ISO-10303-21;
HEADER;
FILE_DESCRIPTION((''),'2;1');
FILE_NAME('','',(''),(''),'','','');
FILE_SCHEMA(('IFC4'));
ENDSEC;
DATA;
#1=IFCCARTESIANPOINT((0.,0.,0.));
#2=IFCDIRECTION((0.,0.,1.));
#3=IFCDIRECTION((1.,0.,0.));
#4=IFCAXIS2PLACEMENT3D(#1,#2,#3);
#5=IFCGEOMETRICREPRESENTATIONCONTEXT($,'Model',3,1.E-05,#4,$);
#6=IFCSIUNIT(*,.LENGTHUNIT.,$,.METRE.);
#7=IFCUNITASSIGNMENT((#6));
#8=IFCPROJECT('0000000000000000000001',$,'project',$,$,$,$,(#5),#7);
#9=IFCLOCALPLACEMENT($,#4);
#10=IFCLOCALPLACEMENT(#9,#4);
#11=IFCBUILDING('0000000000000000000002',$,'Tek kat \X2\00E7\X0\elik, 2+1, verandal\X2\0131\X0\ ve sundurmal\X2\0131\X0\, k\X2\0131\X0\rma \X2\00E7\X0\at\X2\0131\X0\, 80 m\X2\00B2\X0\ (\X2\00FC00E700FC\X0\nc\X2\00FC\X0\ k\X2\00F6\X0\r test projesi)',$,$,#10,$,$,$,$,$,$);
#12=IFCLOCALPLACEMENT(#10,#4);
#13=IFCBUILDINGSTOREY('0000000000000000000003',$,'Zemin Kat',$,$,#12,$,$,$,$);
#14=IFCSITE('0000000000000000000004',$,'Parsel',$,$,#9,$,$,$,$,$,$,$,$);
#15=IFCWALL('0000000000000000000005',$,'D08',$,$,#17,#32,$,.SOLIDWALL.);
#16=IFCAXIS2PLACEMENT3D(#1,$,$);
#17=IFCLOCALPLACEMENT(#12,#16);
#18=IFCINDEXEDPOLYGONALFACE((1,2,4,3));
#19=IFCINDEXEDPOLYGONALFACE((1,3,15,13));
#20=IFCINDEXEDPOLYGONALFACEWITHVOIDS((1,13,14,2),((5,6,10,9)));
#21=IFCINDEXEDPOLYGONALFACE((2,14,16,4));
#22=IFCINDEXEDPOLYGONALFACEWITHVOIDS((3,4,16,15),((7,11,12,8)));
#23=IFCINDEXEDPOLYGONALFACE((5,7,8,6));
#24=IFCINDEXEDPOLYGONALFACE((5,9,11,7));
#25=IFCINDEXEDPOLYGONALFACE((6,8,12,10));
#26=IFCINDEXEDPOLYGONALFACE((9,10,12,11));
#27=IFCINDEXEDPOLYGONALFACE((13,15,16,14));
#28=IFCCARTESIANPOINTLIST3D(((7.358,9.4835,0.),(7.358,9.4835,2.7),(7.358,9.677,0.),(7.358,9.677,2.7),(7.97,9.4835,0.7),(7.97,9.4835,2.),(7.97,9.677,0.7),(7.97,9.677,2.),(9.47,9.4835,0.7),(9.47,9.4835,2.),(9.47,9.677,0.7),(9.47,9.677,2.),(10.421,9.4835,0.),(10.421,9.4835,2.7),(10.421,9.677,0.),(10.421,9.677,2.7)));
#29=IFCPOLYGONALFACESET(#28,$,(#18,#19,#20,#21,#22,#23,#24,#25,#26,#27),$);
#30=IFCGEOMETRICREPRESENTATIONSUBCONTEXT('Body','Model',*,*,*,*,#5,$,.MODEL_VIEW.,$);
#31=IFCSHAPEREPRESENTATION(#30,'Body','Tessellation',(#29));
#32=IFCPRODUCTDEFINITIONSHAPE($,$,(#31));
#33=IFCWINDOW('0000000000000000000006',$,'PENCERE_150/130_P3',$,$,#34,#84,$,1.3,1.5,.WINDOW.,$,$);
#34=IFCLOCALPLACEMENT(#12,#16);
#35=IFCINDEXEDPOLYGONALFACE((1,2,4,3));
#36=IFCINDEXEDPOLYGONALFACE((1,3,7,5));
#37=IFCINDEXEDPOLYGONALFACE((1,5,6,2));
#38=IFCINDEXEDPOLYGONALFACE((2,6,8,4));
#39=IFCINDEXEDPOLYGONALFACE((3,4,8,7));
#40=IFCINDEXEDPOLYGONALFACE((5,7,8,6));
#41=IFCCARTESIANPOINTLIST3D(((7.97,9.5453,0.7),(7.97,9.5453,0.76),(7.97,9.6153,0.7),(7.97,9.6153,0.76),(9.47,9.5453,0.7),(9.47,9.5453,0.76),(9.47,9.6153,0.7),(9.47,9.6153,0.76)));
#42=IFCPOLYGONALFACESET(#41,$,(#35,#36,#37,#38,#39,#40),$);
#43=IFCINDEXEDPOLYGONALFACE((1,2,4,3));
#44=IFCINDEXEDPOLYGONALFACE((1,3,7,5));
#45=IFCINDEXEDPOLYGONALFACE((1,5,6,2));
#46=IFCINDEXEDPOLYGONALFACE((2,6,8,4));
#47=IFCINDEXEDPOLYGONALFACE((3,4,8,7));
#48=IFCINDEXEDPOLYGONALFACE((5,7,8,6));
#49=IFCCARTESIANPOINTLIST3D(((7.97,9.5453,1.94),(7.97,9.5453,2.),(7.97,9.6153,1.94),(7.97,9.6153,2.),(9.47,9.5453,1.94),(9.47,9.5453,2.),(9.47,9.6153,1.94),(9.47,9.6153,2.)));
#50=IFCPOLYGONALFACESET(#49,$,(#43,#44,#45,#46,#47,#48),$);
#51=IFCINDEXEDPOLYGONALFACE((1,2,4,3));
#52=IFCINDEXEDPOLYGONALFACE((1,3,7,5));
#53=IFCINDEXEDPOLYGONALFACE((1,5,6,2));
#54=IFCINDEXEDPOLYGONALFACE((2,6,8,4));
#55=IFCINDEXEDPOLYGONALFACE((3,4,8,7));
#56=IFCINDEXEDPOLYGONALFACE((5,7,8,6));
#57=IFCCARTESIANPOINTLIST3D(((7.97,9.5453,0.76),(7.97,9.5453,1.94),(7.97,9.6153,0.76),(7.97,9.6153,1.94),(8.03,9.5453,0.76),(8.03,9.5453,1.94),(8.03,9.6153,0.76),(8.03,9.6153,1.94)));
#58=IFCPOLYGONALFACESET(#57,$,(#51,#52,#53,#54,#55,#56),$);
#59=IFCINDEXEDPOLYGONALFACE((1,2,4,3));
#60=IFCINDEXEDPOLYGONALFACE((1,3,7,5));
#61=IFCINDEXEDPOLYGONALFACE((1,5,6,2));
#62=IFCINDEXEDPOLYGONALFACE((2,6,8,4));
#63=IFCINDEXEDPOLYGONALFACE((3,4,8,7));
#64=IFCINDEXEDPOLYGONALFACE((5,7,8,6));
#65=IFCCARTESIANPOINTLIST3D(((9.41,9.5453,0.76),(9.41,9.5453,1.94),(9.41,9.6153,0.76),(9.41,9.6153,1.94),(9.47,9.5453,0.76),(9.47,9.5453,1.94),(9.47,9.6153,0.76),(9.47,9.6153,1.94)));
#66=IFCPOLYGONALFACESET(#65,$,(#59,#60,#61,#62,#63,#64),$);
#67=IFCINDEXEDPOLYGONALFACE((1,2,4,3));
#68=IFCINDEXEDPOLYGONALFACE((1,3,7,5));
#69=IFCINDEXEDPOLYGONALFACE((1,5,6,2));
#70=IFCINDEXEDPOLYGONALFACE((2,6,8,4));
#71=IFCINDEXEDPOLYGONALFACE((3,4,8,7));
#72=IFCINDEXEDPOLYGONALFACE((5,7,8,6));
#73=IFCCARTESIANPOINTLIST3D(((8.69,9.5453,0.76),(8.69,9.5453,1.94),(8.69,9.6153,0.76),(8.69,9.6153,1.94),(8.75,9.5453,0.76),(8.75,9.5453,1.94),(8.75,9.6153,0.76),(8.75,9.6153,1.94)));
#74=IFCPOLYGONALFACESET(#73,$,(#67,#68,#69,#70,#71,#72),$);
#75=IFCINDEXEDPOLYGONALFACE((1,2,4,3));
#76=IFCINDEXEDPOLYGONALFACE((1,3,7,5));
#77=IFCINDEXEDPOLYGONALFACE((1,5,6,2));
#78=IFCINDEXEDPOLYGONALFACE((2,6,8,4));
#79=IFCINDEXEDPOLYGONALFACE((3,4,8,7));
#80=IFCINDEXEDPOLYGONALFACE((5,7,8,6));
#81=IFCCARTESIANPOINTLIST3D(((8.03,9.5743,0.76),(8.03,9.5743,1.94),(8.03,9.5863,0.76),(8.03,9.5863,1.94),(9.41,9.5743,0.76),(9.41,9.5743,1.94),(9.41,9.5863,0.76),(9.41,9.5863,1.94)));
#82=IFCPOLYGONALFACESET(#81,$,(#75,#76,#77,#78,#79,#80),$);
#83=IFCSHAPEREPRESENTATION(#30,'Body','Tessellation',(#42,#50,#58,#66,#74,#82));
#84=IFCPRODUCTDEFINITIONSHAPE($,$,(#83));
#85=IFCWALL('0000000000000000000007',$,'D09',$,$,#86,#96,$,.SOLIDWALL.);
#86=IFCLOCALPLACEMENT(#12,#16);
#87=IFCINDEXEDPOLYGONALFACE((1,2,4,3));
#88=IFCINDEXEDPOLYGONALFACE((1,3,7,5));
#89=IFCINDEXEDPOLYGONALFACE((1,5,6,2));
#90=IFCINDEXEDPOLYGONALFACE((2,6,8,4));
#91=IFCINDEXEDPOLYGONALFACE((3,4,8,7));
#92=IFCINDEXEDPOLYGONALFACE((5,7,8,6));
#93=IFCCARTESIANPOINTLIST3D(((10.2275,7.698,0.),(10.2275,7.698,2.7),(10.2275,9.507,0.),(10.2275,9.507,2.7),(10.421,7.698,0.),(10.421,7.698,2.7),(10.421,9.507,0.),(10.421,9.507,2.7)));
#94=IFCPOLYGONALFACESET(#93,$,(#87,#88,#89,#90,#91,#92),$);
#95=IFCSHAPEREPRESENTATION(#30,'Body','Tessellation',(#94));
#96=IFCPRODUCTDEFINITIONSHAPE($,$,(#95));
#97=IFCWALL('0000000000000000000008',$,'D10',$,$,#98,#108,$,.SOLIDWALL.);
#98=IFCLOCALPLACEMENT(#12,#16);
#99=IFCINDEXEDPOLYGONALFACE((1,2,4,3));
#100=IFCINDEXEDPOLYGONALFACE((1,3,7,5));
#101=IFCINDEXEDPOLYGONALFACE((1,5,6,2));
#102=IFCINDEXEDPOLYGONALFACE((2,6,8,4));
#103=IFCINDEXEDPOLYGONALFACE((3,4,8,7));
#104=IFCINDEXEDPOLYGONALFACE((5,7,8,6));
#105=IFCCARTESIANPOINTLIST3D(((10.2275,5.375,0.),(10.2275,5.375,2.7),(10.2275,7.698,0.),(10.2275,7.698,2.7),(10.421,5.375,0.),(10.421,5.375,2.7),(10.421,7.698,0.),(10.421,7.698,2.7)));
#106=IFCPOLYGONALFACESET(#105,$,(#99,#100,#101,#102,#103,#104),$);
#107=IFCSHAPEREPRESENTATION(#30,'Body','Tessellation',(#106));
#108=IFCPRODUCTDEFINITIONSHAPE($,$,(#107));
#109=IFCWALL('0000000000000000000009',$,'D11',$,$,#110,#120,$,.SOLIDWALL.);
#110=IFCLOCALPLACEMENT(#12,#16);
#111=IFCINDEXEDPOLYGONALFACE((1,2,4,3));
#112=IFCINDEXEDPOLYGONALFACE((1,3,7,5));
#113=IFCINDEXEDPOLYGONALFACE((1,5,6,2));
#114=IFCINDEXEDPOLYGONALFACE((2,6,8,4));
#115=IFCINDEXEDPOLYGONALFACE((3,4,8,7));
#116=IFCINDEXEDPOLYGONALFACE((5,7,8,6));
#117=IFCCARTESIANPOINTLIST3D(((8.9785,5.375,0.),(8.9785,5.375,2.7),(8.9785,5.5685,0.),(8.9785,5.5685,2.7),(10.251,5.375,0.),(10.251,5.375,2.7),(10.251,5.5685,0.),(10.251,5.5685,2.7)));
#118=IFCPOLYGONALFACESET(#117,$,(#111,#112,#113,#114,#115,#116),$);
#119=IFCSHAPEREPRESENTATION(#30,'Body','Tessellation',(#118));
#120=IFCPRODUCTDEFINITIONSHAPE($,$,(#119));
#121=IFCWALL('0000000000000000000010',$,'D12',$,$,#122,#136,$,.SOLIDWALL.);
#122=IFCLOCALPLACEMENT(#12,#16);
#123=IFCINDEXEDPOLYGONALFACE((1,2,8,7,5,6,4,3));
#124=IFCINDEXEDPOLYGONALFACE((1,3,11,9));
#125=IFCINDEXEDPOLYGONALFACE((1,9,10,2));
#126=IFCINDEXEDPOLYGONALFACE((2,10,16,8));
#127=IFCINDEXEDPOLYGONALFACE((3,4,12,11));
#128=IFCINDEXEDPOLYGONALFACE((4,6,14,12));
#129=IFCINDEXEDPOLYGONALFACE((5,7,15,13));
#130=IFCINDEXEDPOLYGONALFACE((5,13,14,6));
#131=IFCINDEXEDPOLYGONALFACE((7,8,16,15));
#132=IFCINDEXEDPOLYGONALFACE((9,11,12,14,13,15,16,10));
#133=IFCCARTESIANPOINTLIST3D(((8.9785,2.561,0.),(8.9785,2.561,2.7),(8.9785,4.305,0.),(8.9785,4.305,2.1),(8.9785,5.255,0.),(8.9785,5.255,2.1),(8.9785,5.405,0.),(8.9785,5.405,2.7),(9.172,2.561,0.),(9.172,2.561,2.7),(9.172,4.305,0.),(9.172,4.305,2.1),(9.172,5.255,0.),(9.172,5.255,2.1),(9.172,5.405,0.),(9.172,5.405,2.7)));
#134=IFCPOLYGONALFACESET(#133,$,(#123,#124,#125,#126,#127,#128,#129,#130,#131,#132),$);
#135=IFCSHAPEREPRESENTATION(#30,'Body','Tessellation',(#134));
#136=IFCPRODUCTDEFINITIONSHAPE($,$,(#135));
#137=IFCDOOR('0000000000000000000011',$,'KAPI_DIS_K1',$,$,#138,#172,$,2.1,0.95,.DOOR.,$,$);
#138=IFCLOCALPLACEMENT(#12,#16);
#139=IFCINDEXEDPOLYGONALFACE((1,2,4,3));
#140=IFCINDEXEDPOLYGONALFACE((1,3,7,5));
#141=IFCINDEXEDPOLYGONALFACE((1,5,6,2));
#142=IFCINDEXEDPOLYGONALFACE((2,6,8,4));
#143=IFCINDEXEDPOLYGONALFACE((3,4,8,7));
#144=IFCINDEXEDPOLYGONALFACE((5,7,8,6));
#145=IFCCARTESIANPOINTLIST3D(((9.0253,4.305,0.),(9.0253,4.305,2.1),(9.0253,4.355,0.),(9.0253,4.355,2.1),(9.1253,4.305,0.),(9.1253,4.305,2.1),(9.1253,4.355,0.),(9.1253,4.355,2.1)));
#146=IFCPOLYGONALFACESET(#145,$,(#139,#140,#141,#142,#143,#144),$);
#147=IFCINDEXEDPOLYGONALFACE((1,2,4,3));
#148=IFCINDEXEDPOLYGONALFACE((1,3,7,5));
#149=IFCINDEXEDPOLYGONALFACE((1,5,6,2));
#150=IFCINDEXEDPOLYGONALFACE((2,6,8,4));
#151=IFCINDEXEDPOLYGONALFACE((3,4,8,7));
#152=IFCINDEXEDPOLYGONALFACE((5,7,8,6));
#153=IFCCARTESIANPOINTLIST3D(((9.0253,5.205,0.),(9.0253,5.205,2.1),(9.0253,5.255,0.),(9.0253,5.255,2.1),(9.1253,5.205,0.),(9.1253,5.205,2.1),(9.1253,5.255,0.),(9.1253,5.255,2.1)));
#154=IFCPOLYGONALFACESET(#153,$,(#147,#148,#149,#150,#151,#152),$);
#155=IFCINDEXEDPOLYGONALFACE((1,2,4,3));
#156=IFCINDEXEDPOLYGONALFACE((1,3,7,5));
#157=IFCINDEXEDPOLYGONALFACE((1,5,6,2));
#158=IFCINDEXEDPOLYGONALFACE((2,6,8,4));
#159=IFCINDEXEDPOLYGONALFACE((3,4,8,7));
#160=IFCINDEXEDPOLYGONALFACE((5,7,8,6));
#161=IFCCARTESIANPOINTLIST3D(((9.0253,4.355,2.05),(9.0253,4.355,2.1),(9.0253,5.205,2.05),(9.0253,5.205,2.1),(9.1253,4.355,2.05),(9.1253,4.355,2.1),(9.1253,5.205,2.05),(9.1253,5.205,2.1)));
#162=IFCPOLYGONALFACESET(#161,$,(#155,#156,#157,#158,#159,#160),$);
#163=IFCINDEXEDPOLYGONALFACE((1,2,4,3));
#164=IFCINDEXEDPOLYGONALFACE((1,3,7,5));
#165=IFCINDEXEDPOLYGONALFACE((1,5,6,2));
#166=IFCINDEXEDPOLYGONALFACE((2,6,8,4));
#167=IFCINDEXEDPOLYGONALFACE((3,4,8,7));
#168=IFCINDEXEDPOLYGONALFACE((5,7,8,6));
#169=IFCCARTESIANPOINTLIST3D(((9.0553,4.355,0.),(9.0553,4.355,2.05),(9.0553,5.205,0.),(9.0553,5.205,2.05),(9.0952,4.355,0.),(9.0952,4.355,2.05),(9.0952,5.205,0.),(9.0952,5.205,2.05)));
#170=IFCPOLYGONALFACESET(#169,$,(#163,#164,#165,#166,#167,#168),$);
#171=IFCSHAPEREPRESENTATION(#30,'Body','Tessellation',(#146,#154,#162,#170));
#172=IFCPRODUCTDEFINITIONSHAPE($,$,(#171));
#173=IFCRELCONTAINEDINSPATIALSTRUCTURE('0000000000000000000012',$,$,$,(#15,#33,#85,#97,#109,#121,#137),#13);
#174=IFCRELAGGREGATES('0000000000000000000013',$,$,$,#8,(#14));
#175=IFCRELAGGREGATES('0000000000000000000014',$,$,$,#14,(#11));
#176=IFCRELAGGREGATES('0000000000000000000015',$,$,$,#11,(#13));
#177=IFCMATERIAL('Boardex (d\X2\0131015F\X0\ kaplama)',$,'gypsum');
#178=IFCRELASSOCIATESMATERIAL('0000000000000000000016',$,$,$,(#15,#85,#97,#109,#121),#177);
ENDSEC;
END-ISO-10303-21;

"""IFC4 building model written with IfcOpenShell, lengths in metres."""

from ifc_helpers import new_model, si_unit, frame, origin_with_axes, place, context, subcontext, project, spatial, line, indexed_curve, outline, extrude, material, element, fill, save


model = new_model("IFC4")

# Units and contexts
model_context = context("Model", 3, precision=1e-05, world=origin_with_axes())
body_context = subcontext(model_context, "Body", "Model", "MODEL_VIEW")
ifc_project = project(units=[si_unit("LENGTHUNIT", "METRE")], contexts=[model_context])

# Site, building, storey
site_placement = place(None, origin_with_axes())
site = spatial("IfcSite", under=ifc_project, at=site_placement, Name="Parsel")
building_placement = place(site_placement, origin_with_axes())
building = spatial("IfcBuilding", under=site, at=building_placement, Name="Tek kat çelik, 2+1, verandalı ve sundurmalı, kırma çatı, 80 m² (üçüncü kör test projesi)")
storey_placement = place(building_placement, origin_with_axes())
storey = spatial("IfcBuildingStorey", under=building, at=storey_placement, Name="Zemin Kat")

# Shared definitions
ifc_material_1 = material(Name="Boardex (dış kaplama)", Category="gypsum")

# Wall, opening, window
wall_1_placement = place(storey_placement, origin_with_axes())
wall_1 = element("IfcWall", 1, at=wall_1_placement, inside=storey, material=ifc_material_1, Name="D08", PredefinedType="SOLIDWALL", context=body_context, shape_type="SweptSolid", body=[
    extrude(outline(indexed_curve([(0.0, 0.0), (3.063, 0.0), (3.063, 0.1935), (0.0, 0.1935)], segments=[line(1, 2, 3, 4, 1)])), frame((7.358, 9.4835, 0.0), z_axis=(0.0, 0.0, 1.0), x_axis=(1.0, 0.0, 0.0)), (0.0, 0.0, 1.0), 2.7),
])
opening_1_placement = place(wall_1_placement, origin_with_axes())
opening_1 = element("IfcOpeningElement", 2, at=opening_1_placement, cuts=wall_1, PredefinedType="OPENING", context=body_context, shape_type="SweptSolid", body=[
    extrude(outline(indexed_curve([(0.0, 0.0), (1.5, 0.0), (1.5, 0.2335), (0.0, 0.2335)], segments=[line(1, 2, 3, 4, 1)])), frame((7.97, 9.4635, 0.7), z_axis=(0.0, 0.0, 1.0), x_axis=(1.0, 0.0, 0.0)), (0.0, 0.0, 1.0), 1.3),
])
window_1_placement = place(storey_placement, origin_with_axes())
window_1 = element("IfcWindow", 3, at=window_1_placement, inside=storey, Name="PENCERE_150/130_P3", OverallHeight=1.3, OverallWidth=1.5, PredefinedType="WINDOW", context=body_context, shape_type="SweptSolid", body=[
    extrude(outline(indexed_curve([(0.0, 0.0), (1.5, 0.0), (1.5, 0.07), (0.0, 0.07)], segments=[line(1, 2, 3, 4, 1)])), frame((7.97, 9.5453, 0.7), z_axis=(0.0, 0.0, 1.0), x_axis=(1.0, 0.0, 0.0)), (0.0, 0.0, 1.0), 0.06),
    extrude(outline(indexed_curve([(0.0, 0.0), (1.5, 0.0), (1.5, 0.07), (0.0, 0.07)], segments=[line(1, 2, 3, 4, 1)])), frame((7.97, 9.5453, 1.94), z_axis=(0.0, 0.0, 1.0), x_axis=(1.0, 0.0, 0.0)), (0.0, 0.0, 1.0), 0.06),
    extrude(outline(indexed_curve([(0.0, 0.0), (0.06, 0.0), (0.06, 0.07), (0.0, 0.07)], segments=[line(1, 2, 3, 4, 1)])), frame((7.97, 9.5453, 0.76), z_axis=(0.0, 0.0, 1.0), x_axis=(1.0, 0.0, 0.0)), (0.0, 0.0, 1.0), 1.18),
    extrude(outline(indexed_curve([(0.0, 0.0), (0.06, 0.0), (0.06, 0.07), (0.0, 0.07)], segments=[line(1, 2, 3, 4, 1)])), frame((9.41, 9.5453, 0.76), z_axis=(0.0, 0.0, 1.0), x_axis=(1.0, 0.0, 0.0)), (0.0, 0.0, 1.0), 1.18),
    extrude(outline(indexed_curve([(0.0, 0.0), (0.06, 0.0), (0.06, 0.07), (0.0, 0.07)], segments=[line(1, 2, 3, 4, 1)])), frame((8.69, 9.5453, 0.76), z_axis=(0.0, 0.0, 1.0), x_axis=(1.0, 0.0, 0.0)), (0.0, 0.0, 1.0), 1.18),
    extrude(outline(indexed_curve([(0.0, 0.0), (1.38, 0.0), (1.38, 0.012), (0.0, 0.012)], segments=[line(1, 2, 3, 4, 1)])), frame((8.03, 9.5743, 0.76), z_axis=(0.0, 0.0, 1.0), x_axis=(1.0, 0.0, 0.0)), (0.0, 0.0, 1.0), 1.18),
])
fill(opening_1, window_1)

# Walls
wall_2_placement = place(storey_placement, origin_with_axes())
element("IfcWall", 4, at=wall_2_placement, inside=storey, material=ifc_material_1, Name="D09", PredefinedType="SOLIDWALL", context=body_context, shape_type="SweptSolid", body=[
    extrude(outline(indexed_curve([(0.0, 0.0), (0.1935, 0.0), (0.1935, 1.809), (0.0, 1.809)], segments=[line(1, 2, 3, 4, 1)])), frame((10.2275, 7.698, 0.0), z_axis=(0.0, 0.0, 1.0), x_axis=(1.0, 0.0, 0.0)), (0.0, 0.0, 1.0), 2.7),
])
wall_3_placement = place(storey_placement, origin_with_axes())
element("IfcWall", 5, at=wall_3_placement, inside=storey, material=ifc_material_1, Name="D10", PredefinedType="SOLIDWALL", context=body_context, shape_type="SweptSolid", body=[
    extrude(outline(indexed_curve([(0.0, 0.0), (0.1935, 0.0), (0.1935, 2.323), (0.0, 2.323)], segments=[line(1, 2, 3, 4, 1)])), frame((10.2275, 5.375, 0.0), z_axis=(0.0, 0.0, 1.0), x_axis=(1.0, 0.0, 0.0)), (0.0, 0.0, 1.0), 2.7),
])
wall_4_placement = place(storey_placement, origin_with_axes())
element("IfcWall", 6, at=wall_4_placement, inside=storey, material=ifc_material_1, Name="D11", PredefinedType="SOLIDWALL", context=body_context, shape_type="SweptSolid", body=[
    extrude(outline(indexed_curve([(0.0, 0.0), (1.2725, 0.0), (1.2725, 0.1935), (0.0, 0.1935)], segments=[line(1, 2, 3, 4, 1)])), frame((8.9785, 5.375, 0.0), z_axis=(0.0, 0.0, 1.0), x_axis=(1.0, 0.0, 0.0)), (0.0, 0.0, 1.0), 2.7),
])

# Wall, opening, door
wall_5_placement = place(storey_placement, origin_with_axes())
wall_5 = element("IfcWall", 7, at=wall_5_placement, inside=storey, material=ifc_material_1, Name="D12", PredefinedType="SOLIDWALL", context=body_context, shape_type="SweptSolid", body=[
    extrude(outline(indexed_curve([(0.0, 0.0), (0.1935, 0.0), (0.1935, 2.844), (0.0, 2.844)], segments=[line(1, 2, 3, 4, 1)])), frame((8.9785, 2.561, 0.0), z_axis=(0.0, 0.0, 1.0), x_axis=(1.0, 0.0, 0.0)), (0.0, 0.0, 1.0), 2.7),
])
opening_2_placement = place(wall_5_placement, origin_with_axes())
opening_2 = element("IfcOpeningElement", 8, at=opening_2_placement, cuts=wall_5, PredefinedType="OPENING", context=body_context, shape_type="SweptSolid", body=[
    extrude(outline(indexed_curve([(0.0, 0.0), (0.2335, 0.0), (0.2335, 0.95), (0.0, 0.95)], segments=[line(1, 2, 3, 4, 1)])), frame((8.9585, 4.305, 0.0), z_axis=(0.0, 0.0, 1.0), x_axis=(1.0, 0.0, 0.0)), (0.0, 0.0, 1.0), 2.1),
])
door_1_placement = place(storey_placement, origin_with_axes())
door_1 = element("IfcDoor", 9, at=door_1_placement, inside=storey, Name="KAPI_DIS_K1", OverallHeight=2.1, OverallWidth=0.95, PredefinedType="DOOR", context=body_context, shape_type="SweptSolid", body=[
    extrude(outline(indexed_curve([(0.0, 0.0), (0.1, 0.0), (0.1, 0.05), (0.0, 0.05)], segments=[line(1, 2, 3, 4, 1)])), frame((9.0253, 4.305, 0.0), z_axis=(0.0, 0.0, 1.0), x_axis=(1.0, 0.0, 0.0)), (0.0, 0.0, 1.0), 2.1),
    extrude(outline(indexed_curve([(0.0, 0.0), (0.1, 0.0), (0.1, 0.05), (0.0, 0.05)], segments=[line(1, 2, 3, 4, 1)])), frame((9.0253, 5.205, 0.0), z_axis=(0.0, 0.0, 1.0), x_axis=(1.0, 0.0, 0.0)), (0.0, 0.0, 1.0), 2.1),
    extrude(outline(indexed_curve([(0.0, 0.0), (0.1, 0.0), (0.1, 0.85), (0.0, 0.85)], segments=[line(1, 2, 3, 4, 1)])), frame((9.0253, 4.355, 2.05), z_axis=(0.0, 0.0, 1.0), x_axis=(1.0, 0.0, 0.0)), (0.0, 0.0, 1.0), 0.05),
    extrude(outline(indexed_curve([(0.0, 0.0), (0.04, 0.0), (0.04, 0.85), (0.0, 0.85)], segments=[line(1, 2, 3, 4, 1)])), frame((9.0553, 4.355, 0.0), z_axis=(0.0, 0.0, 1.0), x_axis=(1.0, 0.0, 0.0)), (0.0, 0.0, 1.0), 2.05),
])
fill(opening_2, door_1)

save(model, "model.ifc")
